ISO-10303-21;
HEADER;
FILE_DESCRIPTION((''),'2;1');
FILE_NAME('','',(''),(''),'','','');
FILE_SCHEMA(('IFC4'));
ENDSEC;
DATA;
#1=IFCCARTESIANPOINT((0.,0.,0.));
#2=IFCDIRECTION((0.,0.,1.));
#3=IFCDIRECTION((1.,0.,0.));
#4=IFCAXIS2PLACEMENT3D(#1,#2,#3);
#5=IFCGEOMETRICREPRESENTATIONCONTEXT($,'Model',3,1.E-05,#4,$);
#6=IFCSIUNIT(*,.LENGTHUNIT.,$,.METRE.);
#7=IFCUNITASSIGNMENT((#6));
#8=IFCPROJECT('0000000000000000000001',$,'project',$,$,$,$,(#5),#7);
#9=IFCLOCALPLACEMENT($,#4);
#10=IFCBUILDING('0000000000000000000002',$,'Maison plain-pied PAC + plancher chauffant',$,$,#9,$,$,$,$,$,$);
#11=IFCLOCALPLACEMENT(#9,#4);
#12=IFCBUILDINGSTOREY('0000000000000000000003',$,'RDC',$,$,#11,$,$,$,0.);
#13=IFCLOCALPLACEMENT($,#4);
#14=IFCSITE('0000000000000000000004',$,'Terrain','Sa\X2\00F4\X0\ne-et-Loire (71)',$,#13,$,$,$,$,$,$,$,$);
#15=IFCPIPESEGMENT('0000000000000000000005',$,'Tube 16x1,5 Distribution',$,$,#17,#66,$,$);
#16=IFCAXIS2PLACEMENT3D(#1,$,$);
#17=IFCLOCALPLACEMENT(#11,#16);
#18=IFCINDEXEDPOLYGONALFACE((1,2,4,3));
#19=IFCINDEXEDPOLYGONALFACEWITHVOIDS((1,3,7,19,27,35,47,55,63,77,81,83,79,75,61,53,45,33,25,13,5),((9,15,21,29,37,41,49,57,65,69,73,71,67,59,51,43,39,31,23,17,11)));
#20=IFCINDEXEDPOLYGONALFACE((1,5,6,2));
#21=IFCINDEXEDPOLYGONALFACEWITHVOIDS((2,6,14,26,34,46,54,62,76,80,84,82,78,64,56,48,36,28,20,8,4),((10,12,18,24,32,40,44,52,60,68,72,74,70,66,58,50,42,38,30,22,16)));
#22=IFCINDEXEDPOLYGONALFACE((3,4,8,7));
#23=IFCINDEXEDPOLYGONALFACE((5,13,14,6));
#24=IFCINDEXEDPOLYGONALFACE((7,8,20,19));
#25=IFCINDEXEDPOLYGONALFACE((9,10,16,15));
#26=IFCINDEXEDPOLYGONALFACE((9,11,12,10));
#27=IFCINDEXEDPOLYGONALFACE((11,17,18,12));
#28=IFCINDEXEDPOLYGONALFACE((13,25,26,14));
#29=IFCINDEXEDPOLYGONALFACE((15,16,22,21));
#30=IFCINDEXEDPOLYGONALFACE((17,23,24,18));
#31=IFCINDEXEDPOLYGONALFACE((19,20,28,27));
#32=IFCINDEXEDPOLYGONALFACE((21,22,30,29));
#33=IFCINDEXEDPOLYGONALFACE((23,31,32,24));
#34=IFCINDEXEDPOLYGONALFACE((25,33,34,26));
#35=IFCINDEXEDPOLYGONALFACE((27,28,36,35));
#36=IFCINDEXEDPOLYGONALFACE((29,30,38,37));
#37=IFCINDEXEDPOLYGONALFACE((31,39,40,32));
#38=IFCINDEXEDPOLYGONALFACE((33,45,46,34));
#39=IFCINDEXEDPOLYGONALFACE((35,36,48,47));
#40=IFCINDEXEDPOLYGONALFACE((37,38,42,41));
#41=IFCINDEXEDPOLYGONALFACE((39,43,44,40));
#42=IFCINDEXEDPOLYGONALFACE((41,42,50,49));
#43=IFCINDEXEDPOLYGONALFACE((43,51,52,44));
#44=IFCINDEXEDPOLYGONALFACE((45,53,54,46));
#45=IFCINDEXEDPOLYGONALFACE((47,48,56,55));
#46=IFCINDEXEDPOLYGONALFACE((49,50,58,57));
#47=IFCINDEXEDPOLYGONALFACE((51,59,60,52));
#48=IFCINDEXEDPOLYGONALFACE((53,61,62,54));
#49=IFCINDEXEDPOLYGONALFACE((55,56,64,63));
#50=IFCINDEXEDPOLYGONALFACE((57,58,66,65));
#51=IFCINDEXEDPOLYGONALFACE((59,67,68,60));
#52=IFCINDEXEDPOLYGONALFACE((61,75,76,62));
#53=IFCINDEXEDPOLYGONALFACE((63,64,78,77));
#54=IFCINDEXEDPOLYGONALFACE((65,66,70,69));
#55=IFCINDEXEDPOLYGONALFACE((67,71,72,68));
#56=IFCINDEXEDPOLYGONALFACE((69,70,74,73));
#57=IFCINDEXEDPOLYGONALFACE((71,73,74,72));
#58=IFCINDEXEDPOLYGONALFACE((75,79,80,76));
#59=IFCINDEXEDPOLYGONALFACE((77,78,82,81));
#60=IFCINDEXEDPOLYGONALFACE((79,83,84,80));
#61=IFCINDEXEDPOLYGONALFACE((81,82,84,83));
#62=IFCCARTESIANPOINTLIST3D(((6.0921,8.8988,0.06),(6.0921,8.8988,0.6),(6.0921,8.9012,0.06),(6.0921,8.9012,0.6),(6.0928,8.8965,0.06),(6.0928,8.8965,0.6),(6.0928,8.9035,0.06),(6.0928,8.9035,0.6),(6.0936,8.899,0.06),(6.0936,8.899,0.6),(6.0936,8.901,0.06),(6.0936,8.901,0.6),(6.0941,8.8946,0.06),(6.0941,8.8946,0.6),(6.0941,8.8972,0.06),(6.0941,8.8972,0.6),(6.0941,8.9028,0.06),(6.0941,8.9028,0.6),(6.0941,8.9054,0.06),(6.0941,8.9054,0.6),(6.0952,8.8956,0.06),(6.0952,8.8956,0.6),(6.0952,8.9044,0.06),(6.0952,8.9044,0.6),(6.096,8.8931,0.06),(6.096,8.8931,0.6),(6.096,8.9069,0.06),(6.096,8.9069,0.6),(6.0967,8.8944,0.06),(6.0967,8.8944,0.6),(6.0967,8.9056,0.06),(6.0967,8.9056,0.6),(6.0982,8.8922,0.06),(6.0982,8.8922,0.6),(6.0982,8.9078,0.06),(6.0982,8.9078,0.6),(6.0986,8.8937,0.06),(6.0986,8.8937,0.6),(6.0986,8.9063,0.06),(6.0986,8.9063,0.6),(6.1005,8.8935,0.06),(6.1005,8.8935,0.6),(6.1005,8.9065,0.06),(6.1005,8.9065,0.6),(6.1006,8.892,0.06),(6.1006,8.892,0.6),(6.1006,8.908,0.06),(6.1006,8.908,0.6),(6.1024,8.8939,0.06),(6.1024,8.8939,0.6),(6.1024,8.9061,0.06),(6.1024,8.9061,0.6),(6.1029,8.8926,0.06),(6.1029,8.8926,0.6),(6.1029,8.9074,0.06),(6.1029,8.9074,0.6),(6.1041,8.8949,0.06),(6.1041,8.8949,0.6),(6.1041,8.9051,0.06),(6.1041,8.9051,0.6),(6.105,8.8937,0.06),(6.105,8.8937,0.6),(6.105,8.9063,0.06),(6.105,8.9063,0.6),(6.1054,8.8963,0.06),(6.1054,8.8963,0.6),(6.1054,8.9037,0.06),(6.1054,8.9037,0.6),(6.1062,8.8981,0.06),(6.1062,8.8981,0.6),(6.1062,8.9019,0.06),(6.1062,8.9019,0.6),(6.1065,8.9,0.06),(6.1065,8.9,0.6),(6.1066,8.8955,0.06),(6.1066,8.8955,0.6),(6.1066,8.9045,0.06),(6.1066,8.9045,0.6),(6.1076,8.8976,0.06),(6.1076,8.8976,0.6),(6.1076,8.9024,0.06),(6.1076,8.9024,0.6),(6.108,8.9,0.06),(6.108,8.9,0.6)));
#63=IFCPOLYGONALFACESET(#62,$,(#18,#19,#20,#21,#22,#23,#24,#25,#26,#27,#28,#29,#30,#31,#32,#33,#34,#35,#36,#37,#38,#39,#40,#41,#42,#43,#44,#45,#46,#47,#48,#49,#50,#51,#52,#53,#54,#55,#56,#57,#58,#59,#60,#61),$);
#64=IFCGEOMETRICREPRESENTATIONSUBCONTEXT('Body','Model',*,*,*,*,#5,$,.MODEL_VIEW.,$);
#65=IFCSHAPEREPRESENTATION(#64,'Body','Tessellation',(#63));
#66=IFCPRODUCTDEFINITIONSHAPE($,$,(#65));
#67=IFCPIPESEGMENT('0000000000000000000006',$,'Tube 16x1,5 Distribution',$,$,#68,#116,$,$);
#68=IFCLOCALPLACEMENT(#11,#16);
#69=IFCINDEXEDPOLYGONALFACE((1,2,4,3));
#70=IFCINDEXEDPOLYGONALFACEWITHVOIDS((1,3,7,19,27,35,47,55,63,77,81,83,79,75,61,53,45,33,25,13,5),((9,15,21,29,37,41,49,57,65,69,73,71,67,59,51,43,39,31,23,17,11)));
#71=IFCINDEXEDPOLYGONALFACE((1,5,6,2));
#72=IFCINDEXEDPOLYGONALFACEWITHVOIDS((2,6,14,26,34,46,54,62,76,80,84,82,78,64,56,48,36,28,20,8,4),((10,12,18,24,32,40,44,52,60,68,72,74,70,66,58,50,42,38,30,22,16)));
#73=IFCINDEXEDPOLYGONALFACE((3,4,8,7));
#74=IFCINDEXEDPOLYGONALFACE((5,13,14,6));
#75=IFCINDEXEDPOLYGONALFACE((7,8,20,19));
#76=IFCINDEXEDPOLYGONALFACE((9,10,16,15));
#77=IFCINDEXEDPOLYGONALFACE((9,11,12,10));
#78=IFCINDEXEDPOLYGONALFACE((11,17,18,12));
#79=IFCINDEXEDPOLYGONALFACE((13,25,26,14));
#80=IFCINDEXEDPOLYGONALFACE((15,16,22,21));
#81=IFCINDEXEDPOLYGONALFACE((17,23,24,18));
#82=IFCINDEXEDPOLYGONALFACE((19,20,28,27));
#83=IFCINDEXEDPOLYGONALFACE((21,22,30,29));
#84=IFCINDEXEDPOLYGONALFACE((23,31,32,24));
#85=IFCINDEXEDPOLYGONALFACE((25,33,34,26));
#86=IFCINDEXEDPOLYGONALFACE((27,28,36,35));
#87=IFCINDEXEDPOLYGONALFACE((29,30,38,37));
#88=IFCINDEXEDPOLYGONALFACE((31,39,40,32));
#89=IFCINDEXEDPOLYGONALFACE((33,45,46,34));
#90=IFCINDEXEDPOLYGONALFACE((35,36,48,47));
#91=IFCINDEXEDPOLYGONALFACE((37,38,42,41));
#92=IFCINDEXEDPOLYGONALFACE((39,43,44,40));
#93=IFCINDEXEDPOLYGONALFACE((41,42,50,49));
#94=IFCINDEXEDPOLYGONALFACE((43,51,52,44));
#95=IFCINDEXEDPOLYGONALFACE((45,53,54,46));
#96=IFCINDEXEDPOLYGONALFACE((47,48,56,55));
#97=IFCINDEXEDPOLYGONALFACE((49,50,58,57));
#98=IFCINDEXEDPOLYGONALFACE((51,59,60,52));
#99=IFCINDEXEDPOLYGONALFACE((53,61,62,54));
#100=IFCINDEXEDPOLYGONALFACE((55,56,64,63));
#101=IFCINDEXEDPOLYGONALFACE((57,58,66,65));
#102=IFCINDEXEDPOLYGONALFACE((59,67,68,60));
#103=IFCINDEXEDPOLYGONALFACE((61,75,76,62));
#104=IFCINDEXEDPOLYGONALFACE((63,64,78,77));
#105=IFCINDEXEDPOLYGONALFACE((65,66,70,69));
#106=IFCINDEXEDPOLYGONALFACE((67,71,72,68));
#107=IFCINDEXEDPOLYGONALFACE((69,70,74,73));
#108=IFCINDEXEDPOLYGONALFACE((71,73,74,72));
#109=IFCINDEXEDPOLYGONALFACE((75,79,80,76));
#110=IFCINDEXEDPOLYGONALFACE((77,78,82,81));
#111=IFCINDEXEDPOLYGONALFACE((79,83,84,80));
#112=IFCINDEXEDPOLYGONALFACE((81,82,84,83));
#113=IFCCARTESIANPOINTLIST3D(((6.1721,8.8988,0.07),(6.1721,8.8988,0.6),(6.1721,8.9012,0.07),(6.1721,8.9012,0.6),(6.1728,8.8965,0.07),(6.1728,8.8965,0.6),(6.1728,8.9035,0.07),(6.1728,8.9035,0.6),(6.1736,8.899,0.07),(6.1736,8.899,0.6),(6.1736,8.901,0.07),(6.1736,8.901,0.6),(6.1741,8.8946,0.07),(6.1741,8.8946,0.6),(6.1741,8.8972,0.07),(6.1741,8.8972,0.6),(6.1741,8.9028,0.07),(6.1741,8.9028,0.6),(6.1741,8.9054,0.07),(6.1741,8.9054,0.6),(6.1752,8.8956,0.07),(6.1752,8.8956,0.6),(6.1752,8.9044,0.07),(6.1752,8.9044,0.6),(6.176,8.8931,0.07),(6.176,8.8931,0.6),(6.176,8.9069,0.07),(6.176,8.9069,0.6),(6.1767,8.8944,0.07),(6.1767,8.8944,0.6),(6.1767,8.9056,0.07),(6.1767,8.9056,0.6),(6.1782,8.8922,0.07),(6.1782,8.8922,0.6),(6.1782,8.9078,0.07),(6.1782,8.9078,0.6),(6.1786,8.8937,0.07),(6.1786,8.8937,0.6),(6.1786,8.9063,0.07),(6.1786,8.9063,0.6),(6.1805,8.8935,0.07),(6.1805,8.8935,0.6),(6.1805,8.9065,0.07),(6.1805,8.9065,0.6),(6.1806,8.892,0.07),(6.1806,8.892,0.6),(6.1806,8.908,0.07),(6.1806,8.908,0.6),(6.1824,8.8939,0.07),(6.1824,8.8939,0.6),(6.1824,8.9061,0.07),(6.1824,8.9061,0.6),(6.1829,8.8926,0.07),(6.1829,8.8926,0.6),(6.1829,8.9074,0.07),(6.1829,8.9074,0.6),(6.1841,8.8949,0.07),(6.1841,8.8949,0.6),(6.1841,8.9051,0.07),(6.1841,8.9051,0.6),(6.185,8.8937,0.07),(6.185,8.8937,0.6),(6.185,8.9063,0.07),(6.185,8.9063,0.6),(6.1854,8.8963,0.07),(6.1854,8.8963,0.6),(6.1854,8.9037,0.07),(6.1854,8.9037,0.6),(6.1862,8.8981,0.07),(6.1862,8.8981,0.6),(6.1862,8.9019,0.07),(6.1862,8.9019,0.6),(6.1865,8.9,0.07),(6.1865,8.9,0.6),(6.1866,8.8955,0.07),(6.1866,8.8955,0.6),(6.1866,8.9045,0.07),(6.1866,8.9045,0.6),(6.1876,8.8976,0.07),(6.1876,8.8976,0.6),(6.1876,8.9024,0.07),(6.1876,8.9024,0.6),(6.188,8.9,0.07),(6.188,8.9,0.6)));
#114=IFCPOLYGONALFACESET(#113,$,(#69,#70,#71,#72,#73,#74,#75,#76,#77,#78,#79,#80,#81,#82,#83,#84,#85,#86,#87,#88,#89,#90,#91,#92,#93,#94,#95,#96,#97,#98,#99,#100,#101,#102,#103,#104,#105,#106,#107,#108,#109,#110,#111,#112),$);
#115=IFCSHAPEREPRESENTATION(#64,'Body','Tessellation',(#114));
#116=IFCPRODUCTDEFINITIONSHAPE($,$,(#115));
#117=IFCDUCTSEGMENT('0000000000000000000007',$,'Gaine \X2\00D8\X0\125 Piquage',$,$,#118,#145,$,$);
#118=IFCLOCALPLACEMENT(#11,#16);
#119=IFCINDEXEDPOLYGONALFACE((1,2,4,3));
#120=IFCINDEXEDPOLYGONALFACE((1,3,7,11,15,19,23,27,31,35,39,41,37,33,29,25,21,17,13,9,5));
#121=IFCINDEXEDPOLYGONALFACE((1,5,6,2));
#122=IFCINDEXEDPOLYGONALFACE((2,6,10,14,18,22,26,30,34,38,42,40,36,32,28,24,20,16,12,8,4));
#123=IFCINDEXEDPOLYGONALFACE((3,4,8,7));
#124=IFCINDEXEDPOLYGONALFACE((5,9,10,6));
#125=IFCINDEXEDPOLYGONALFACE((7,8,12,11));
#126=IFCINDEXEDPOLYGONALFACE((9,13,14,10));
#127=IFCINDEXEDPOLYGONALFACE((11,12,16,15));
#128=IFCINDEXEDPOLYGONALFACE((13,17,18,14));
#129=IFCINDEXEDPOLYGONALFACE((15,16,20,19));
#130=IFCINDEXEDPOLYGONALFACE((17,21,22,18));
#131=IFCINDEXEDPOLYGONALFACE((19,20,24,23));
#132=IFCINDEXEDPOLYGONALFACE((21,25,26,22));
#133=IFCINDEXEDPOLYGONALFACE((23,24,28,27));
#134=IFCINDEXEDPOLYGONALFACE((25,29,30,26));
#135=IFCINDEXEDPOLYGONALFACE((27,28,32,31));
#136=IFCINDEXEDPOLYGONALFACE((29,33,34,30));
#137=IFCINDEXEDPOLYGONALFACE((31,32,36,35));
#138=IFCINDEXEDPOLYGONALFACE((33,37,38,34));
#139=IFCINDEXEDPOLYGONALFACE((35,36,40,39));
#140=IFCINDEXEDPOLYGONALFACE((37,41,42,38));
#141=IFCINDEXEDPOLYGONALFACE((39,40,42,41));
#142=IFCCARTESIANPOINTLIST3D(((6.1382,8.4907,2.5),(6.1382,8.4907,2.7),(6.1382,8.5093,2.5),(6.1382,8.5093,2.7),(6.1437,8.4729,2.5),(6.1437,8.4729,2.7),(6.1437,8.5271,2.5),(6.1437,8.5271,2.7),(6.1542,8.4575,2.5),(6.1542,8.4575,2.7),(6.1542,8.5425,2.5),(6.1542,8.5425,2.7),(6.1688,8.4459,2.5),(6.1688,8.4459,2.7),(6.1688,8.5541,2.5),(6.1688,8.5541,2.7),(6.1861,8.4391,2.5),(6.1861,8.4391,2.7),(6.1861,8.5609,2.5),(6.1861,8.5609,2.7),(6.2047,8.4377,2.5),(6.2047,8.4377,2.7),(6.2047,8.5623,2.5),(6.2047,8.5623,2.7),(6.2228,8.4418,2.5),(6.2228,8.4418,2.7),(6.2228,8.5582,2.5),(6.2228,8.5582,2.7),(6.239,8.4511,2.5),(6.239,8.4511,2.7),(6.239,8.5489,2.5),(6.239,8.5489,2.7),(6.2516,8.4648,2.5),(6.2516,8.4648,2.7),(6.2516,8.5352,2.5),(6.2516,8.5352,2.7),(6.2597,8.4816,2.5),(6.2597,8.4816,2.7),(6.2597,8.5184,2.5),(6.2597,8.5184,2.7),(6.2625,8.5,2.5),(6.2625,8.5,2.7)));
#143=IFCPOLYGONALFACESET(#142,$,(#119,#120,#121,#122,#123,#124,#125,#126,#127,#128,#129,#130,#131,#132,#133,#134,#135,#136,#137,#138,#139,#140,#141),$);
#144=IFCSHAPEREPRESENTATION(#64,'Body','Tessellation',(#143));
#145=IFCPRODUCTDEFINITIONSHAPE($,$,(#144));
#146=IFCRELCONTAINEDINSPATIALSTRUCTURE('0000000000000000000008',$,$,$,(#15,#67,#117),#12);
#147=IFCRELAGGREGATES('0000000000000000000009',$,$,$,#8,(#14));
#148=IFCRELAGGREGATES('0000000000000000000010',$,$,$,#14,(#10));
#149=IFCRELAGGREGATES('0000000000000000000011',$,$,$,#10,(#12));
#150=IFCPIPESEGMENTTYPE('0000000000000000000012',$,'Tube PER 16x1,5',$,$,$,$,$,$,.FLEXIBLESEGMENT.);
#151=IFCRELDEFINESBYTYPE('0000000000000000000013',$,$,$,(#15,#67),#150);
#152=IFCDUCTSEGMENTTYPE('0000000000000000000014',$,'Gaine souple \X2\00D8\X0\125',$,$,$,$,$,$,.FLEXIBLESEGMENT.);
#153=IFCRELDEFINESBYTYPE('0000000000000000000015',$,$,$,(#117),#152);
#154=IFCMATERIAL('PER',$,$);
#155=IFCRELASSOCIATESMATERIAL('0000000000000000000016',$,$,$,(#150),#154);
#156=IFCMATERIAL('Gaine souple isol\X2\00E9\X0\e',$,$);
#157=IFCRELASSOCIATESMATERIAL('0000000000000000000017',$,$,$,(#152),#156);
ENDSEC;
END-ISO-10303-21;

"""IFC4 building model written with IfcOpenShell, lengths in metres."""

from ifc_helpers import new_model, si_unit, frame, origin_with_axes, place, context, subcontext, project, spatial, circle, hollow_circle, extrude, material, type_object, element, save


model = new_model("IFC4")

# Units and contexts
model_context = context("Model", 3, precision=1e-05, world=origin_with_axes())
body_context = subcontext(model_context, "Body", "Model", "MODEL_VIEW")
ifc_project = project(units=[si_unit("LENGTHUNIT", "METRE")], contexts=[model_context])

# Site, building, storey
site_placement = place(None, origin_with_axes())
site = spatial("IfcSite", under=ifc_project, at=site_placement, Name="Terrain", Description="Saône-et-Loire (71)")
building_placement = place(None, origin_with_axes())
building = spatial("IfcBuilding", under=site, at=building_placement, Name="Maison plain-pied PAC + plancher chauffant")
storey_placement = place(building_placement, origin_with_axes())
storey = spatial("IfcBuildingStorey", under=building, at=storey_placement, Name="RDC", Elevation=0.0)

# Pipe segments
ifc_material_1 = material(Name="PER")
pipe_segment_type_1 = type_object("IfcPipeSegmentType", Name="Tube PER 16x1,5", PredefinedType="FLEXIBLESEGMENT", material=ifc_material_1)
pipe_segment_1_placement = place(storey_placement, frame((6.1, 8.9, 0.06), z_axis=(0.0, 0.0, 1.0), x_axis=(1.0, 0.0, 0.0)))
element("IfcPipeSegment", 1, at=pipe_segment_1_placement, inside=storey, type_object=pipe_segment_type_1, Name="Tube 16x1,5 Distribution", context=body_context, shape_type="SweptSolid", body=[
    extrude(hollow_circle(Radius=0.008, WallThickness=0.0015), origin_with_axes(), (0.0, 0.0, 1.0), 0.54),
])
pipe_segment_2_placement = place(storey_placement, frame((6.18, 8.9, 0.07), z_axis=(0.0, 0.0, 1.0), x_axis=(1.0, 0.0, 0.0)))
element("IfcPipeSegment", 2, at=pipe_segment_2_placement, inside=storey, type_object=pipe_segment_type_1, Name="Tube 16x1,5 Distribution", context=body_context, shape_type="SweptSolid", body=[
    extrude(hollow_circle(Radius=0.008, WallThickness=0.0015), origin_with_axes(), (0.0, 0.0, 1.0), 0.53),
])

# Duct segment
ifc_material_2 = material(Name="Gaine souple isolée")
duct_segment_type = type_object("IfcDuctSegmentType", Name="Gaine souple Ø125", PredefinedType="FLEXIBLESEGMENT", material=ifc_material_2)
duct_segment_placement = place(storey_placement, frame((6.2, 8.5, 2.5), z_axis=(0.0, 0.0, 1.0), x_axis=(1.0, 0.0, 0.0)))
element("IfcDuctSegment", 3, at=duct_segment_placement, inside=storey, type_object=duct_segment_type, Name="Gaine Ø125 Piquage", context=body_context, shape_type="SweptSolid", body=[
    extrude(circle(Radius=0.0625), origin_with_axes(), (0.0, 0.0, 1.0), 0.2),
])

save(model, "model.ifc")
